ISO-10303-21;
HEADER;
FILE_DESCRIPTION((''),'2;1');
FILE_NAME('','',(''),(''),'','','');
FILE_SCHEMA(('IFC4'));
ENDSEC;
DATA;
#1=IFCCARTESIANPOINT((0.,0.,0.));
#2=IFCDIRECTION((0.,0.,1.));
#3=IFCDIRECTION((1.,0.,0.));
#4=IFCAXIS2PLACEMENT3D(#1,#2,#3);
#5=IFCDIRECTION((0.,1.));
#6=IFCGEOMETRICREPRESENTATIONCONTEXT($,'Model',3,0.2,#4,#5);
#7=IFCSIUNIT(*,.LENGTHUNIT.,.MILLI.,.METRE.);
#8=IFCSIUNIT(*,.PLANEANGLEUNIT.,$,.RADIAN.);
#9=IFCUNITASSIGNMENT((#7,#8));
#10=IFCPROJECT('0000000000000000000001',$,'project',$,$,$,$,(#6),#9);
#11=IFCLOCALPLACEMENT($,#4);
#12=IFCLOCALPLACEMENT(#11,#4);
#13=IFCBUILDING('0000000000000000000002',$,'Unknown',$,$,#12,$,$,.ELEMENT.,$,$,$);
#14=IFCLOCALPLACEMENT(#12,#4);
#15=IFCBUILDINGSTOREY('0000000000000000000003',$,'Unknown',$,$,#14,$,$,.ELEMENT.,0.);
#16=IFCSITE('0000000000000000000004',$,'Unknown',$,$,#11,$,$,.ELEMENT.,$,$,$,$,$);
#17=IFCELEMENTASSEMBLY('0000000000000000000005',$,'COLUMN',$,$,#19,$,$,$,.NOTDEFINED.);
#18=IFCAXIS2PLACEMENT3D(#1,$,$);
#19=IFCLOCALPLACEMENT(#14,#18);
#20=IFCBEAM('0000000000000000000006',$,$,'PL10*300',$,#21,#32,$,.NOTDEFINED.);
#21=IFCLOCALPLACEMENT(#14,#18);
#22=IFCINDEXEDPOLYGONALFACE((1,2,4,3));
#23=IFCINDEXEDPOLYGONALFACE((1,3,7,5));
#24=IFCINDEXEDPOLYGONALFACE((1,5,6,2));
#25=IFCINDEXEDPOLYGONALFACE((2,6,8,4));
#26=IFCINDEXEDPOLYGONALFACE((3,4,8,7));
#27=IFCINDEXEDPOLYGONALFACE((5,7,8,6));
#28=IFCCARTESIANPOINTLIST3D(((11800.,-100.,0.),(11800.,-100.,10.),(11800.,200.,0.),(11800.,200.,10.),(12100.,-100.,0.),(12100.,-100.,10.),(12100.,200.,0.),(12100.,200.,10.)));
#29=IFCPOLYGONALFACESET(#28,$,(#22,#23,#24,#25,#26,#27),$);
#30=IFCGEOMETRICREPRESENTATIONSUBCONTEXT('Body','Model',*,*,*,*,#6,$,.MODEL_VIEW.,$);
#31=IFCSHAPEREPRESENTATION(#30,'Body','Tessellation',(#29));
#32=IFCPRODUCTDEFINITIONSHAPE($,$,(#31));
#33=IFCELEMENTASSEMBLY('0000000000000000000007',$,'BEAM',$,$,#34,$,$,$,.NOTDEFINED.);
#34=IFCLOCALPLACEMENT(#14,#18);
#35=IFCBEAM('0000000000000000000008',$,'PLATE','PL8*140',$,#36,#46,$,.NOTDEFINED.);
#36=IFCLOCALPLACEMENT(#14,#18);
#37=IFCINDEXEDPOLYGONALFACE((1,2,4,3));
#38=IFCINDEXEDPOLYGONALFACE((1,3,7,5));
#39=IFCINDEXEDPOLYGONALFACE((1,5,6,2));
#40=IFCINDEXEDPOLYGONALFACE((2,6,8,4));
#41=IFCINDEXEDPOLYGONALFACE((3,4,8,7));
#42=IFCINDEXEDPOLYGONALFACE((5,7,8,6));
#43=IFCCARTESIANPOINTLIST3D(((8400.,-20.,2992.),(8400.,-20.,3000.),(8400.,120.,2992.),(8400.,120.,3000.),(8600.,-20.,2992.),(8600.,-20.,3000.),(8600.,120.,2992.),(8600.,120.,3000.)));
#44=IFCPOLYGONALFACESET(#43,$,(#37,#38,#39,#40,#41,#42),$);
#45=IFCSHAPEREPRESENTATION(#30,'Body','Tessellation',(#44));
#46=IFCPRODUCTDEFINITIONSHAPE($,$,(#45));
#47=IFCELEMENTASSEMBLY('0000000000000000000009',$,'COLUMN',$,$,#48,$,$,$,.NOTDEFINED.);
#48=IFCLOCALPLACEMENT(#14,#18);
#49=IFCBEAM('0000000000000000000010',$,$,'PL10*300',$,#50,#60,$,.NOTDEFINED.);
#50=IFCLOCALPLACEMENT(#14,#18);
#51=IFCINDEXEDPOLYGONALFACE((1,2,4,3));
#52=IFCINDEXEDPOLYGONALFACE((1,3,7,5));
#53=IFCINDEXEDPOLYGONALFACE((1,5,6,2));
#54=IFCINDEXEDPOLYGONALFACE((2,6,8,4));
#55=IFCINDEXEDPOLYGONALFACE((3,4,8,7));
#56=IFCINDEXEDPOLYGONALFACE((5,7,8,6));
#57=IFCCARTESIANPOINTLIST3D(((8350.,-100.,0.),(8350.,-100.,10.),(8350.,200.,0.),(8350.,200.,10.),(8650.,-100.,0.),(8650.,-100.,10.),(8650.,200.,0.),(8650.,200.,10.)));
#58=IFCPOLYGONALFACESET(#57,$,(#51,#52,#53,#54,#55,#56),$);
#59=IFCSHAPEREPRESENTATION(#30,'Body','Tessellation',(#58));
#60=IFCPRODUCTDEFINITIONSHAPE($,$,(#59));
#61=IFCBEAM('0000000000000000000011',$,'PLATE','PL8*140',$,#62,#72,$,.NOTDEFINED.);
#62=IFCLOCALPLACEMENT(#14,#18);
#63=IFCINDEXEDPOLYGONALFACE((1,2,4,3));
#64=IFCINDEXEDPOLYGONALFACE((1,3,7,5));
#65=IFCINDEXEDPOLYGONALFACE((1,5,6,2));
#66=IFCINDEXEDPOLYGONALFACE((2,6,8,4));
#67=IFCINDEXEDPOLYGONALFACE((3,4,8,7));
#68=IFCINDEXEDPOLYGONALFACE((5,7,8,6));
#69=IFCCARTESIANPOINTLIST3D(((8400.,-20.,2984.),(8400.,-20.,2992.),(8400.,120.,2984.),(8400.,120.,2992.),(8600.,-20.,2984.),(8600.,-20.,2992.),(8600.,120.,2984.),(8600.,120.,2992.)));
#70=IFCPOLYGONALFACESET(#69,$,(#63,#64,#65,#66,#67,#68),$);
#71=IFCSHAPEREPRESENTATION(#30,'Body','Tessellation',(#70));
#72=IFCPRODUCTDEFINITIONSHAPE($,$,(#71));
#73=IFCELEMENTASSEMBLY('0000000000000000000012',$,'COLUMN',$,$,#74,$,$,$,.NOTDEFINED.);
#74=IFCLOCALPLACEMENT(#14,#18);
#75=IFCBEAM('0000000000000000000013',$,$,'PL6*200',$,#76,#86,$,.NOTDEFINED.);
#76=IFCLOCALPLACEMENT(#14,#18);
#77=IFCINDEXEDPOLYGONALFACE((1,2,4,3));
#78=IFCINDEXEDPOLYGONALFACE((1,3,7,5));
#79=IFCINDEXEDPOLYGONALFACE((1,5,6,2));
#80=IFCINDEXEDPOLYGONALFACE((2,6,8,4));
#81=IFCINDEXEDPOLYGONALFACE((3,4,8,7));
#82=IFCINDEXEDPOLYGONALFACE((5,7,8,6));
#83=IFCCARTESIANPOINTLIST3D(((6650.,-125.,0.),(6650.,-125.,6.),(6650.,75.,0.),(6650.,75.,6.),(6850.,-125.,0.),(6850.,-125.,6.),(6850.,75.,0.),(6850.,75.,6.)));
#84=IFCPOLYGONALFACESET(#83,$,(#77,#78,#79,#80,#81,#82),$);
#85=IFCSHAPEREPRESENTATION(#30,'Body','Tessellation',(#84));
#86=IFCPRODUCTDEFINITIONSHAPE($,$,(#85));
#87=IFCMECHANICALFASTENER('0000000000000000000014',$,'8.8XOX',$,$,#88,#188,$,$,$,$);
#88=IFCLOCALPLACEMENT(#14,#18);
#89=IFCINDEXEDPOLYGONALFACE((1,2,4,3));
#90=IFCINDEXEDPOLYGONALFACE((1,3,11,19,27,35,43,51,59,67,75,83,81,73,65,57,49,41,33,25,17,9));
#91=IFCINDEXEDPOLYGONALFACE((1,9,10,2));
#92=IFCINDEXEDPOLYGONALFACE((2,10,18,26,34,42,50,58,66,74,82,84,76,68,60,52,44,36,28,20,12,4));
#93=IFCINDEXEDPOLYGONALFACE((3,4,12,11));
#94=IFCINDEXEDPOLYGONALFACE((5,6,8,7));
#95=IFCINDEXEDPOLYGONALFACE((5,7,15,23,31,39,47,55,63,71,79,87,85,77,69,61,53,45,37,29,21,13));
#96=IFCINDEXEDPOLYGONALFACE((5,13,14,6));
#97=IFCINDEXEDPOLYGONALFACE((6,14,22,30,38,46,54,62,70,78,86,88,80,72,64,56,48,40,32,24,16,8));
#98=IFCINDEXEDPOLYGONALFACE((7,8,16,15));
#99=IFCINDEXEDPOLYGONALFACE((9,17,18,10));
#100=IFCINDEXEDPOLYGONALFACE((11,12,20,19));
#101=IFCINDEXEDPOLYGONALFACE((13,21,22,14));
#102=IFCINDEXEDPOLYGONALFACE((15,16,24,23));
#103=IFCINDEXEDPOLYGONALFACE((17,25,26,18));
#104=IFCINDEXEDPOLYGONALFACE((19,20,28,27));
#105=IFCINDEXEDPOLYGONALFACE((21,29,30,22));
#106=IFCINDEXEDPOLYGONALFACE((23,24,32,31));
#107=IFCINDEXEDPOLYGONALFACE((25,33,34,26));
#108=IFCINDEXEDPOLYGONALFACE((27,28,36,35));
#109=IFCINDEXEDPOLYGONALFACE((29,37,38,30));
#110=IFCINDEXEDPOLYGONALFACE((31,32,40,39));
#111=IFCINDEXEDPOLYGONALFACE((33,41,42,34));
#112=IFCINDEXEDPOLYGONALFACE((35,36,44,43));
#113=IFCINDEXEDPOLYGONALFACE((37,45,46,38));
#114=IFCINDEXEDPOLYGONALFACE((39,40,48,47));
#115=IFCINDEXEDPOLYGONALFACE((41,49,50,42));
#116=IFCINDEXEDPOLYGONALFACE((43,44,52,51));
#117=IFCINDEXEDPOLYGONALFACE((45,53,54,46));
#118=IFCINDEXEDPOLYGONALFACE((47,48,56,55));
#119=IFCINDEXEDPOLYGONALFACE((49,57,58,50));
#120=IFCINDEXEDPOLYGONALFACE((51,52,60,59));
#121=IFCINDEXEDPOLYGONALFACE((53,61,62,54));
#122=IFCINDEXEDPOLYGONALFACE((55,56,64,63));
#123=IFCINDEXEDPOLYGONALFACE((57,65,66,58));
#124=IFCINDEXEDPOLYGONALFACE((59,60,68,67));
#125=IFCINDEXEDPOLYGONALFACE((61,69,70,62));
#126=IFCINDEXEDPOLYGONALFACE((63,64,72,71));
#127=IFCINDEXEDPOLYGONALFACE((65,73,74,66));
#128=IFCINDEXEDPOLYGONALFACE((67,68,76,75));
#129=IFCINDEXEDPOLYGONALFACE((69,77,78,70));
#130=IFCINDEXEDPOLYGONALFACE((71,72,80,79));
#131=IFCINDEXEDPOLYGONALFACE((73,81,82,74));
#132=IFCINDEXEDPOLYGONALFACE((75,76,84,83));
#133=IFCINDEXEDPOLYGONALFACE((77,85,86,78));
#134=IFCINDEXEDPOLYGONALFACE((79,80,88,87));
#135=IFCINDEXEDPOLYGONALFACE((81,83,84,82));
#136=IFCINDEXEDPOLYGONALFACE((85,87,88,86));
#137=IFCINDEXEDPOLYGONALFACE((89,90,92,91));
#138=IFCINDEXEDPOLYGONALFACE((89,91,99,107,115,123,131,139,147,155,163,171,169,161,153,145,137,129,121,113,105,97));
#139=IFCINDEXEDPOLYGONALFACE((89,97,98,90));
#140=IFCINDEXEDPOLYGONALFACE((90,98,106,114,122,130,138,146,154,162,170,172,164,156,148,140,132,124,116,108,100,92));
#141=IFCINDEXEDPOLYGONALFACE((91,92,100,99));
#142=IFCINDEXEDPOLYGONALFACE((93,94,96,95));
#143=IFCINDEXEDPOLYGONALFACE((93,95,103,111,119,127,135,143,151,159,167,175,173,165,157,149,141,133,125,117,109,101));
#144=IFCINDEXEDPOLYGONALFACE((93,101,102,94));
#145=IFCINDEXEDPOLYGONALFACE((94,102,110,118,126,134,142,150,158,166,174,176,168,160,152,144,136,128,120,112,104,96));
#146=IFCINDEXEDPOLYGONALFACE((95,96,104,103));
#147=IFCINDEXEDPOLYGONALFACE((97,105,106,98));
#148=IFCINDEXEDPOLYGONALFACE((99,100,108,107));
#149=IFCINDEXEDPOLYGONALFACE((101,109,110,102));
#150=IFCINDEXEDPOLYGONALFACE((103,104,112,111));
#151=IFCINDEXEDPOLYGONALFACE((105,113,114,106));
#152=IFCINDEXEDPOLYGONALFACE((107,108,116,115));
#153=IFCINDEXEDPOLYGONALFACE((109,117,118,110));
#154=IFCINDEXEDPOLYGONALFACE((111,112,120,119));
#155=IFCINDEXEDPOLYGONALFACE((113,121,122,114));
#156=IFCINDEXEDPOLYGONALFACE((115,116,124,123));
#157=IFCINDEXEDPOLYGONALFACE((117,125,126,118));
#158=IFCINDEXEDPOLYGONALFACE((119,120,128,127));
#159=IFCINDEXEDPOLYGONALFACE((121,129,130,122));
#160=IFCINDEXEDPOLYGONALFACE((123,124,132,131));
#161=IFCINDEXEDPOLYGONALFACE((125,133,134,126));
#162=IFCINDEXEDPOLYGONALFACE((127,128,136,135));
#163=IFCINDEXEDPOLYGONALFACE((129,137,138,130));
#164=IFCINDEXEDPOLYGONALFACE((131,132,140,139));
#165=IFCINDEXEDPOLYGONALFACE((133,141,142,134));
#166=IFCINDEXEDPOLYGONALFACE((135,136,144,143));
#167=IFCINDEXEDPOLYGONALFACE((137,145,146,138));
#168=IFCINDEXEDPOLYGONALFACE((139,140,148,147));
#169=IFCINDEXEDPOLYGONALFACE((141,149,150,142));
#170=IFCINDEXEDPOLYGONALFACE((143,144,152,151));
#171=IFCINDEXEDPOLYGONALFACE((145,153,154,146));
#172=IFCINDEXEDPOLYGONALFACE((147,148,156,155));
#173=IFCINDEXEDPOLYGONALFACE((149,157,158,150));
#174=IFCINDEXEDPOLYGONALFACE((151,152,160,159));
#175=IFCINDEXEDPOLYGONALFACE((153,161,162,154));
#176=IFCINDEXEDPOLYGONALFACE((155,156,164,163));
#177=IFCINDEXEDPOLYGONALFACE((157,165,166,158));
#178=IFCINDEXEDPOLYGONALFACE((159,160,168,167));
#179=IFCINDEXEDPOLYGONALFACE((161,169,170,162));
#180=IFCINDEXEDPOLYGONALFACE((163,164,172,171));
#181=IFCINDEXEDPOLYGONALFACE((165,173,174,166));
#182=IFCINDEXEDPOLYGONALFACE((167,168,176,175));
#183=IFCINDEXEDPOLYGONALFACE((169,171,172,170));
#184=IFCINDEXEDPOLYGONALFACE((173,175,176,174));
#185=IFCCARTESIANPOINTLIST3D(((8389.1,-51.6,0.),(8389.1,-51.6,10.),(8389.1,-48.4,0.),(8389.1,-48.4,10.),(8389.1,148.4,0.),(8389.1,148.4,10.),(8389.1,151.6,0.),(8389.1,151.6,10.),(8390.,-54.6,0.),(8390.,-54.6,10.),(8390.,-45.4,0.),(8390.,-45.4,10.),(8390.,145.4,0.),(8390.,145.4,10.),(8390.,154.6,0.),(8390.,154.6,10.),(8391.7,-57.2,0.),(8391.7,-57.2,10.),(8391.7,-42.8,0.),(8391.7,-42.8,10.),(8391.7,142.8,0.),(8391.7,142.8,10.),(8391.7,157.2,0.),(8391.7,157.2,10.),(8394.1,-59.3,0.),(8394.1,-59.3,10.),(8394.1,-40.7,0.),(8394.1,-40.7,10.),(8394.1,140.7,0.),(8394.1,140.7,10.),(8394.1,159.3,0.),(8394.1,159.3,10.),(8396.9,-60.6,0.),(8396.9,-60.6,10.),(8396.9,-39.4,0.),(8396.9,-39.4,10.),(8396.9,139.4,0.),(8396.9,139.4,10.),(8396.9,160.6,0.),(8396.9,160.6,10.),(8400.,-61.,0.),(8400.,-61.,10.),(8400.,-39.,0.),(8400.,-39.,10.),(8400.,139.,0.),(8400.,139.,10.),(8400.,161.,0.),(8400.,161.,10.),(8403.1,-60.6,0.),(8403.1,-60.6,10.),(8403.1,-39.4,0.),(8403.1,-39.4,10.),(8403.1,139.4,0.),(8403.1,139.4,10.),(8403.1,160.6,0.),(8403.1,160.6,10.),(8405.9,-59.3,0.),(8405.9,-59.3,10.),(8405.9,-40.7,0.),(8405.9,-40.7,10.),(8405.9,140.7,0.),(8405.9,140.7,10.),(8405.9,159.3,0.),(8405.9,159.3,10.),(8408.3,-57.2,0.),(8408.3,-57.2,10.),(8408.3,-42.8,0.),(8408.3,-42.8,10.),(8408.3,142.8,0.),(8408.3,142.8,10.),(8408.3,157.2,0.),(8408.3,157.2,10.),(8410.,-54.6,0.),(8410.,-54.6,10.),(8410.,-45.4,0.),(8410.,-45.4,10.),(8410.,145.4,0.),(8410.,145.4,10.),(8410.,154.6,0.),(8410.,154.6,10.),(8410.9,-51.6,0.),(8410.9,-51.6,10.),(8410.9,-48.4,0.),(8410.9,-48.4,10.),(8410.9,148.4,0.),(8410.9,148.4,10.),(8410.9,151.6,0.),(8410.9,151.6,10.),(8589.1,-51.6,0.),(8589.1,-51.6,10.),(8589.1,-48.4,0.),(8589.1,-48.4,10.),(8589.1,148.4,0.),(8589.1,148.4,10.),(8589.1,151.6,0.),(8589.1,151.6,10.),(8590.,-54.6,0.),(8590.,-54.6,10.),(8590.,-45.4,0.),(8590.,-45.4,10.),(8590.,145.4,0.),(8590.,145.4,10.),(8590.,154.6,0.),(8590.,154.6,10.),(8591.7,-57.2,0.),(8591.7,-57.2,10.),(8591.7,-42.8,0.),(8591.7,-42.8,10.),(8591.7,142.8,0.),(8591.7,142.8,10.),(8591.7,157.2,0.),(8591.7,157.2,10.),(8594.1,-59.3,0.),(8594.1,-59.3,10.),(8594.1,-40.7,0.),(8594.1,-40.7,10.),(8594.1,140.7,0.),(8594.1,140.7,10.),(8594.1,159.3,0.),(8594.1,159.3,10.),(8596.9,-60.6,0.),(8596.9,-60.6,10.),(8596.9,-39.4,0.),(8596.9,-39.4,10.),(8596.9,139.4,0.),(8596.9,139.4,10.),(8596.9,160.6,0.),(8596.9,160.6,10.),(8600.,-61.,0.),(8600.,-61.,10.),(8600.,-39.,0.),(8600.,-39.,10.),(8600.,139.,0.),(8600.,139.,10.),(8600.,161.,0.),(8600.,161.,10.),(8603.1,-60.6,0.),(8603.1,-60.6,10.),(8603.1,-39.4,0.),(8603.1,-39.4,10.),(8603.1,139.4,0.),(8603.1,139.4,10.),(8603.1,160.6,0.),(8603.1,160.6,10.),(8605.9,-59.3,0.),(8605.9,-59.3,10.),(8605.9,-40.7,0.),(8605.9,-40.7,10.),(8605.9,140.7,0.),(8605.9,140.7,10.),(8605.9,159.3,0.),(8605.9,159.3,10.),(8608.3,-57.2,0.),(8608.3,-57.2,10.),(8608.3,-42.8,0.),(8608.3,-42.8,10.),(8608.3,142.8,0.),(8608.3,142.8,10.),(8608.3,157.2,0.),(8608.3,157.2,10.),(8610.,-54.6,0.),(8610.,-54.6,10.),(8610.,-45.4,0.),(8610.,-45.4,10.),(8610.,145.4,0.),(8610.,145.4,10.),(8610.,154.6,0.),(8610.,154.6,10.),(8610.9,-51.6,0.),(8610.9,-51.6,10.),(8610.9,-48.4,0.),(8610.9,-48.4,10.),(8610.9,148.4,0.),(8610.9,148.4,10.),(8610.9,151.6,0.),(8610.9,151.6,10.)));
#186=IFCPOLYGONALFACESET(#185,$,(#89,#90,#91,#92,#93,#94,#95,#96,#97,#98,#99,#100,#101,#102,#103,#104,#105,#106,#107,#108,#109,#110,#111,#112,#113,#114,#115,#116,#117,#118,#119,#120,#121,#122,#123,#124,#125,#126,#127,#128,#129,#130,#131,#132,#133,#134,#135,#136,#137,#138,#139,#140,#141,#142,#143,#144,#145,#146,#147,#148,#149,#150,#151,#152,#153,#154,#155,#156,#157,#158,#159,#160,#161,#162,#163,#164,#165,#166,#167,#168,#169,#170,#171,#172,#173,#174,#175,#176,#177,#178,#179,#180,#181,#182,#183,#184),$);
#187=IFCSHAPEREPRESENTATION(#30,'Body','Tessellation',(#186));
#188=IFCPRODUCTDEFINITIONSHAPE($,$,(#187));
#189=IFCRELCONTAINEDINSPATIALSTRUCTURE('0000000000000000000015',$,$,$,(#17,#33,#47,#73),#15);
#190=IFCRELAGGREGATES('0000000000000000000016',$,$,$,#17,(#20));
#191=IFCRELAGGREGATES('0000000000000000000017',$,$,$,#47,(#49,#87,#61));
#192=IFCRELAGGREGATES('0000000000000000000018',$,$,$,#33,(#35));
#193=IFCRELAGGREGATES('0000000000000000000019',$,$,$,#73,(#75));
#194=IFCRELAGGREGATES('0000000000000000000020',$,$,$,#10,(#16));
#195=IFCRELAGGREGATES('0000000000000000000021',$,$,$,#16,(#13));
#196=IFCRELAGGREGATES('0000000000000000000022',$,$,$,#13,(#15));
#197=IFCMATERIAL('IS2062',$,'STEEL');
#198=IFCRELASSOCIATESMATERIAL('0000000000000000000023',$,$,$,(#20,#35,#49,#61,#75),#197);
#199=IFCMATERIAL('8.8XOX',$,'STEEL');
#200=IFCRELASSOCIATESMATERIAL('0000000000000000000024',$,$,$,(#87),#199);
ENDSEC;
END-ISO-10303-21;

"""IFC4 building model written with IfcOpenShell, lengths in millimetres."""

from ifc_helpers import new_model, si_unit, direction, frame, origin_with_axes, place, context, subcontext, project, spatial, line, arc, indexed_curve, outline, extrude, source, transform, mapped, material, element, aggregate, save


model = new_model("IFC4")

# Units and contexts
model_context = context("Model", 3, precision=0.2, world=origin_with_axes(), true_north=direction((0.0, 1.0)))
body_context = subcontext(model_context, "Body", "Model", "MODEL_VIEW")
ifc_project = project(units=[si_unit("LENGTHUNIT", "METRE", prefix="MILLI"), si_unit("PLANEANGLEUNIT", "RADIAN")], contexts=[model_context])

# Site, building, storey
site_placement = place(None, origin_with_axes())
site = spatial("IfcSite", under=ifc_project, at=site_placement, Name="Unknown", CompositionType="ELEMENT")
building_placement = place(site_placement, origin_with_axes())
building = spatial("IfcBuilding", under=site, at=building_placement, Name="Unknown", CompositionType="ELEMENT")
storey_placement = place(building_placement, origin_with_axes())
storey = spatial("IfcBuildingStorey", under=building, at=storey_placement, Name="Unknown", CompositionType="ELEMENT", Elevation=0.0)

# Element assembly, beam
assembly_1_placement = place(storey_placement, frame((11950.0, 50.0, 0.0), z_axis=(0.0, 1.0, 0.0), x_axis=(0.0, 0.0, 1.0)))
assembly_1 = element("IfcElementAssembly", 1, at=assembly_1_placement, inside=storey, Name="COLUMN", PredefinedType="NOTDEFINED")
ifc_material_1 = material(Name="IS2062", Category="STEEL")
beam_1_placement = place(assembly_1_placement, frame((5.0, -150.0, 0.0), z_axis=(1.0, 0.0, 0.0), x_axis=(0.0, 1.0, 0.0)))
beam_1 = element("IfcBeam", 2, at=beam_1_placement, material=ifc_material_1, Description="PL10*300", PredefinedType="NOTDEFINED", context=body_context, shape_type="SolidModel", body=[
    extrude(outline(indexed_curve([(-5.0, -150.0), (5.0, -150.0), (5.0, 150.0), (-5.0, 150.0)], segments=[line(1, 2, 3, 4, 1)])), frame((0.0, 0.0, 0.0), z_axis=(-1.0, 0.0, 0.0), x_axis=(0.0, 0.0, 1.0)), (0.0, 0.0, -1.0), 300.0),
])
aggregate(assembly_1, [beam_1])

# Element assembly, beam
assembly_2_placement = place(storey_placement, frame((-50.0, 50.0, 3025.0), z_axis=(0.0, -1.0, 0.0), x_axis=(1.0, 0.0, 0.0)))
assembly_2 = element("IfcElementAssembly", 3, at=assembly_2_placement, inside=storey, Name="BEAM", PredefinedType="NOTDEFINED")
beam_2_placement = place(assembly_2_placement, frame((8650.0, -29.0, 0.0), z_axis=(0.0, -1.0, 0.0), x_axis=(-1.0, 0.0, 0.0)))
beam_2 = element("IfcBeam", 4, at=beam_2_placement, material=ifc_material_1, Name="PLATE", Description="PL8*140", PredefinedType="NOTDEFINED", context=body_context, shape_type="SolidModel", body=[
    extrude(outline(indexed_curve([(-4.0, -70.0), (4.0, -70.0), (4.0, 70.0), (-4.0, 70.0)], segments=[line(1, 2, 3, 4, 1)])), frame((0.0, 0.0, 0.0), z_axis=(-1.0, 0.0, 0.0), x_axis=(0.0, 0.0, 1.0)), (0.0, 0.0, -1.0), 200.0),
])

# Element assembly, beams
assembly_3_placement = place(storey_placement, frame((8500.0, 50.0, 0.0), z_axis=(0.0, 1.0, 0.0), x_axis=(0.0, 0.0, 1.0)))
assembly_3 = element("IfcElementAssembly", 5, at=assembly_3_placement, inside=storey, Name="COLUMN", PredefinedType="NOTDEFINED")
beam_3_placement = place(assembly_3_placement, frame((5.0, -150.0, 0.0), z_axis=(1.0, 0.0, 0.0), x_axis=(0.0, 1.0, 0.0)))
beam_3 = element("IfcBeam", 6, at=beam_3_placement, material=ifc_material_1, Description="PL10*300", PredefinedType="NOTDEFINED", context=body_context, shape_type="SolidModel", body=[
    extrude(outline(indexed_curve([(-5.0, -150.0), (5.0, -150.0), (5.0, 150.0), (-5.0, 150.0)], segments=[line(1, 2, 3, 4, 1)])), frame((0.0, 0.0, 0.0), z_axis=(-1.0, 0.0, 0.0), x_axis=(0.0, 0.0, 1.0)), (0.0, 0.0, -1.0), 300.0),
])
beam_4_placement = place(assembly_3_placement, frame((2988.0, 100.0, 0.0), z_axis=(-1.0, 0.0, 0.0), x_axis=(0.0, -1.0, 0.0)))
beam_4 = element("IfcBeam", 7, at=beam_4_placement, material=ifc_material_1, Name="PLATE", Description="PL8*140", PredefinedType="NOTDEFINED", context=body_context, shape_type="SolidModel", body=[
    extrude(outline(indexed_curve([(-4.0, -70.0), (4.0, -70.0), (4.0, 70.0), (-4.0, 70.0)], segments=[line(1, 2, 3, 4, 1)])), frame((0.0, 0.0, 0.0), z_axis=(-1.0, 0.0, 0.0), x_axis=(0.0, 0.0, 1.0)), (0.0, 0.0, -1.0), 200.0),
])

# Element assembly, beam
assembly_4_placement = place(storey_placement, frame((6750.0, -25.0, 0.0), z_axis=(0.0, 1.0, 0.0), x_axis=(0.0, 0.0, 1.0)))
assembly_4 = element("IfcElementAssembly", 8, at=assembly_4_placement, inside=storey, Name="COLUMN", PredefinedType="NOTDEFINED")
beam_5_placement = place(assembly_4_placement, frame((3.0, -100.0, 0.0), z_axis=(1.0, 0.0, 0.0), x_axis=(0.0, 1.0, 0.0)))
beam_5 = element("IfcBeam", 9, at=beam_5_placement, material=ifc_material_1, Description="PL6*200", PredefinedType="NOTDEFINED", context=body_context, shape_type="SolidModel", body=[
    extrude(outline(indexed_curve([(-3.0, -100.0), (3.0, -100.0), (3.0, 100.0), (-3.0, 100.0)], segments=[line(1, 2, 3, 4, 1)])), frame((0.0, 0.0, 0.0), z_axis=(-1.0, 0.0, 0.0), x_axis=(0.0, 0.0, 1.0)), (0.0, 0.0, -1.0), 200.0),
])

# Mechanical fastener
ifc_material_2 = material(Name="8.8XOX", Category="STEEL")
shared_shape_1 = source(origin_with_axes(), body_context, "Body", "SweptSolid", [
    extrude(outline(indexed_curve([(11.0, 0.0), (0.0, 11.0), (-11.0, 0.0), (0.0, -11.0)], segments=[arc(1, 2, 3), arc(3, 4, 1)])), frame((0.0, 0.0, 0.0), z_axis=(0.0, 0.0, -1.0), x_axis=(0.0, 1.0, 0.0)), (0.0, 0.0, 1.0), 10.0),
])
mechanical_fastener_1_placement = place(assembly_3_placement, frame((10.0, 50.0, 0.0), z_axis=(1.0, 0.0, 0.0), x_axis=(0.0, -1.0, 0.0)))
mechanical_fastener_1 = element("IfcMechanicalFastener", 10, at=mechanical_fastener_1_placement, material=ifc_material_2, Name="8.8XOX", context=body_context, shape_type="MappedRepresentation", body=[
    mapped(shared_shape_1, transform((-50.0, 100.0, 0.0))),
    mapped(shared_shape_1, transform((-50.0, -100.0, 0.0))),
    mapped(shared_shape_1, transform((150.0, 100.0, 0.0))),
    mapped(shared_shape_1, transform((150.0, -100.0, 0.0))),
])
aggregate(assembly_3, [beam_3, mechanical_fastener_1, beam_4])
aggregate(assembly_2, [beam_2])

aggregate(assembly_4, [beam_5])

save(model, "model.ifc")
